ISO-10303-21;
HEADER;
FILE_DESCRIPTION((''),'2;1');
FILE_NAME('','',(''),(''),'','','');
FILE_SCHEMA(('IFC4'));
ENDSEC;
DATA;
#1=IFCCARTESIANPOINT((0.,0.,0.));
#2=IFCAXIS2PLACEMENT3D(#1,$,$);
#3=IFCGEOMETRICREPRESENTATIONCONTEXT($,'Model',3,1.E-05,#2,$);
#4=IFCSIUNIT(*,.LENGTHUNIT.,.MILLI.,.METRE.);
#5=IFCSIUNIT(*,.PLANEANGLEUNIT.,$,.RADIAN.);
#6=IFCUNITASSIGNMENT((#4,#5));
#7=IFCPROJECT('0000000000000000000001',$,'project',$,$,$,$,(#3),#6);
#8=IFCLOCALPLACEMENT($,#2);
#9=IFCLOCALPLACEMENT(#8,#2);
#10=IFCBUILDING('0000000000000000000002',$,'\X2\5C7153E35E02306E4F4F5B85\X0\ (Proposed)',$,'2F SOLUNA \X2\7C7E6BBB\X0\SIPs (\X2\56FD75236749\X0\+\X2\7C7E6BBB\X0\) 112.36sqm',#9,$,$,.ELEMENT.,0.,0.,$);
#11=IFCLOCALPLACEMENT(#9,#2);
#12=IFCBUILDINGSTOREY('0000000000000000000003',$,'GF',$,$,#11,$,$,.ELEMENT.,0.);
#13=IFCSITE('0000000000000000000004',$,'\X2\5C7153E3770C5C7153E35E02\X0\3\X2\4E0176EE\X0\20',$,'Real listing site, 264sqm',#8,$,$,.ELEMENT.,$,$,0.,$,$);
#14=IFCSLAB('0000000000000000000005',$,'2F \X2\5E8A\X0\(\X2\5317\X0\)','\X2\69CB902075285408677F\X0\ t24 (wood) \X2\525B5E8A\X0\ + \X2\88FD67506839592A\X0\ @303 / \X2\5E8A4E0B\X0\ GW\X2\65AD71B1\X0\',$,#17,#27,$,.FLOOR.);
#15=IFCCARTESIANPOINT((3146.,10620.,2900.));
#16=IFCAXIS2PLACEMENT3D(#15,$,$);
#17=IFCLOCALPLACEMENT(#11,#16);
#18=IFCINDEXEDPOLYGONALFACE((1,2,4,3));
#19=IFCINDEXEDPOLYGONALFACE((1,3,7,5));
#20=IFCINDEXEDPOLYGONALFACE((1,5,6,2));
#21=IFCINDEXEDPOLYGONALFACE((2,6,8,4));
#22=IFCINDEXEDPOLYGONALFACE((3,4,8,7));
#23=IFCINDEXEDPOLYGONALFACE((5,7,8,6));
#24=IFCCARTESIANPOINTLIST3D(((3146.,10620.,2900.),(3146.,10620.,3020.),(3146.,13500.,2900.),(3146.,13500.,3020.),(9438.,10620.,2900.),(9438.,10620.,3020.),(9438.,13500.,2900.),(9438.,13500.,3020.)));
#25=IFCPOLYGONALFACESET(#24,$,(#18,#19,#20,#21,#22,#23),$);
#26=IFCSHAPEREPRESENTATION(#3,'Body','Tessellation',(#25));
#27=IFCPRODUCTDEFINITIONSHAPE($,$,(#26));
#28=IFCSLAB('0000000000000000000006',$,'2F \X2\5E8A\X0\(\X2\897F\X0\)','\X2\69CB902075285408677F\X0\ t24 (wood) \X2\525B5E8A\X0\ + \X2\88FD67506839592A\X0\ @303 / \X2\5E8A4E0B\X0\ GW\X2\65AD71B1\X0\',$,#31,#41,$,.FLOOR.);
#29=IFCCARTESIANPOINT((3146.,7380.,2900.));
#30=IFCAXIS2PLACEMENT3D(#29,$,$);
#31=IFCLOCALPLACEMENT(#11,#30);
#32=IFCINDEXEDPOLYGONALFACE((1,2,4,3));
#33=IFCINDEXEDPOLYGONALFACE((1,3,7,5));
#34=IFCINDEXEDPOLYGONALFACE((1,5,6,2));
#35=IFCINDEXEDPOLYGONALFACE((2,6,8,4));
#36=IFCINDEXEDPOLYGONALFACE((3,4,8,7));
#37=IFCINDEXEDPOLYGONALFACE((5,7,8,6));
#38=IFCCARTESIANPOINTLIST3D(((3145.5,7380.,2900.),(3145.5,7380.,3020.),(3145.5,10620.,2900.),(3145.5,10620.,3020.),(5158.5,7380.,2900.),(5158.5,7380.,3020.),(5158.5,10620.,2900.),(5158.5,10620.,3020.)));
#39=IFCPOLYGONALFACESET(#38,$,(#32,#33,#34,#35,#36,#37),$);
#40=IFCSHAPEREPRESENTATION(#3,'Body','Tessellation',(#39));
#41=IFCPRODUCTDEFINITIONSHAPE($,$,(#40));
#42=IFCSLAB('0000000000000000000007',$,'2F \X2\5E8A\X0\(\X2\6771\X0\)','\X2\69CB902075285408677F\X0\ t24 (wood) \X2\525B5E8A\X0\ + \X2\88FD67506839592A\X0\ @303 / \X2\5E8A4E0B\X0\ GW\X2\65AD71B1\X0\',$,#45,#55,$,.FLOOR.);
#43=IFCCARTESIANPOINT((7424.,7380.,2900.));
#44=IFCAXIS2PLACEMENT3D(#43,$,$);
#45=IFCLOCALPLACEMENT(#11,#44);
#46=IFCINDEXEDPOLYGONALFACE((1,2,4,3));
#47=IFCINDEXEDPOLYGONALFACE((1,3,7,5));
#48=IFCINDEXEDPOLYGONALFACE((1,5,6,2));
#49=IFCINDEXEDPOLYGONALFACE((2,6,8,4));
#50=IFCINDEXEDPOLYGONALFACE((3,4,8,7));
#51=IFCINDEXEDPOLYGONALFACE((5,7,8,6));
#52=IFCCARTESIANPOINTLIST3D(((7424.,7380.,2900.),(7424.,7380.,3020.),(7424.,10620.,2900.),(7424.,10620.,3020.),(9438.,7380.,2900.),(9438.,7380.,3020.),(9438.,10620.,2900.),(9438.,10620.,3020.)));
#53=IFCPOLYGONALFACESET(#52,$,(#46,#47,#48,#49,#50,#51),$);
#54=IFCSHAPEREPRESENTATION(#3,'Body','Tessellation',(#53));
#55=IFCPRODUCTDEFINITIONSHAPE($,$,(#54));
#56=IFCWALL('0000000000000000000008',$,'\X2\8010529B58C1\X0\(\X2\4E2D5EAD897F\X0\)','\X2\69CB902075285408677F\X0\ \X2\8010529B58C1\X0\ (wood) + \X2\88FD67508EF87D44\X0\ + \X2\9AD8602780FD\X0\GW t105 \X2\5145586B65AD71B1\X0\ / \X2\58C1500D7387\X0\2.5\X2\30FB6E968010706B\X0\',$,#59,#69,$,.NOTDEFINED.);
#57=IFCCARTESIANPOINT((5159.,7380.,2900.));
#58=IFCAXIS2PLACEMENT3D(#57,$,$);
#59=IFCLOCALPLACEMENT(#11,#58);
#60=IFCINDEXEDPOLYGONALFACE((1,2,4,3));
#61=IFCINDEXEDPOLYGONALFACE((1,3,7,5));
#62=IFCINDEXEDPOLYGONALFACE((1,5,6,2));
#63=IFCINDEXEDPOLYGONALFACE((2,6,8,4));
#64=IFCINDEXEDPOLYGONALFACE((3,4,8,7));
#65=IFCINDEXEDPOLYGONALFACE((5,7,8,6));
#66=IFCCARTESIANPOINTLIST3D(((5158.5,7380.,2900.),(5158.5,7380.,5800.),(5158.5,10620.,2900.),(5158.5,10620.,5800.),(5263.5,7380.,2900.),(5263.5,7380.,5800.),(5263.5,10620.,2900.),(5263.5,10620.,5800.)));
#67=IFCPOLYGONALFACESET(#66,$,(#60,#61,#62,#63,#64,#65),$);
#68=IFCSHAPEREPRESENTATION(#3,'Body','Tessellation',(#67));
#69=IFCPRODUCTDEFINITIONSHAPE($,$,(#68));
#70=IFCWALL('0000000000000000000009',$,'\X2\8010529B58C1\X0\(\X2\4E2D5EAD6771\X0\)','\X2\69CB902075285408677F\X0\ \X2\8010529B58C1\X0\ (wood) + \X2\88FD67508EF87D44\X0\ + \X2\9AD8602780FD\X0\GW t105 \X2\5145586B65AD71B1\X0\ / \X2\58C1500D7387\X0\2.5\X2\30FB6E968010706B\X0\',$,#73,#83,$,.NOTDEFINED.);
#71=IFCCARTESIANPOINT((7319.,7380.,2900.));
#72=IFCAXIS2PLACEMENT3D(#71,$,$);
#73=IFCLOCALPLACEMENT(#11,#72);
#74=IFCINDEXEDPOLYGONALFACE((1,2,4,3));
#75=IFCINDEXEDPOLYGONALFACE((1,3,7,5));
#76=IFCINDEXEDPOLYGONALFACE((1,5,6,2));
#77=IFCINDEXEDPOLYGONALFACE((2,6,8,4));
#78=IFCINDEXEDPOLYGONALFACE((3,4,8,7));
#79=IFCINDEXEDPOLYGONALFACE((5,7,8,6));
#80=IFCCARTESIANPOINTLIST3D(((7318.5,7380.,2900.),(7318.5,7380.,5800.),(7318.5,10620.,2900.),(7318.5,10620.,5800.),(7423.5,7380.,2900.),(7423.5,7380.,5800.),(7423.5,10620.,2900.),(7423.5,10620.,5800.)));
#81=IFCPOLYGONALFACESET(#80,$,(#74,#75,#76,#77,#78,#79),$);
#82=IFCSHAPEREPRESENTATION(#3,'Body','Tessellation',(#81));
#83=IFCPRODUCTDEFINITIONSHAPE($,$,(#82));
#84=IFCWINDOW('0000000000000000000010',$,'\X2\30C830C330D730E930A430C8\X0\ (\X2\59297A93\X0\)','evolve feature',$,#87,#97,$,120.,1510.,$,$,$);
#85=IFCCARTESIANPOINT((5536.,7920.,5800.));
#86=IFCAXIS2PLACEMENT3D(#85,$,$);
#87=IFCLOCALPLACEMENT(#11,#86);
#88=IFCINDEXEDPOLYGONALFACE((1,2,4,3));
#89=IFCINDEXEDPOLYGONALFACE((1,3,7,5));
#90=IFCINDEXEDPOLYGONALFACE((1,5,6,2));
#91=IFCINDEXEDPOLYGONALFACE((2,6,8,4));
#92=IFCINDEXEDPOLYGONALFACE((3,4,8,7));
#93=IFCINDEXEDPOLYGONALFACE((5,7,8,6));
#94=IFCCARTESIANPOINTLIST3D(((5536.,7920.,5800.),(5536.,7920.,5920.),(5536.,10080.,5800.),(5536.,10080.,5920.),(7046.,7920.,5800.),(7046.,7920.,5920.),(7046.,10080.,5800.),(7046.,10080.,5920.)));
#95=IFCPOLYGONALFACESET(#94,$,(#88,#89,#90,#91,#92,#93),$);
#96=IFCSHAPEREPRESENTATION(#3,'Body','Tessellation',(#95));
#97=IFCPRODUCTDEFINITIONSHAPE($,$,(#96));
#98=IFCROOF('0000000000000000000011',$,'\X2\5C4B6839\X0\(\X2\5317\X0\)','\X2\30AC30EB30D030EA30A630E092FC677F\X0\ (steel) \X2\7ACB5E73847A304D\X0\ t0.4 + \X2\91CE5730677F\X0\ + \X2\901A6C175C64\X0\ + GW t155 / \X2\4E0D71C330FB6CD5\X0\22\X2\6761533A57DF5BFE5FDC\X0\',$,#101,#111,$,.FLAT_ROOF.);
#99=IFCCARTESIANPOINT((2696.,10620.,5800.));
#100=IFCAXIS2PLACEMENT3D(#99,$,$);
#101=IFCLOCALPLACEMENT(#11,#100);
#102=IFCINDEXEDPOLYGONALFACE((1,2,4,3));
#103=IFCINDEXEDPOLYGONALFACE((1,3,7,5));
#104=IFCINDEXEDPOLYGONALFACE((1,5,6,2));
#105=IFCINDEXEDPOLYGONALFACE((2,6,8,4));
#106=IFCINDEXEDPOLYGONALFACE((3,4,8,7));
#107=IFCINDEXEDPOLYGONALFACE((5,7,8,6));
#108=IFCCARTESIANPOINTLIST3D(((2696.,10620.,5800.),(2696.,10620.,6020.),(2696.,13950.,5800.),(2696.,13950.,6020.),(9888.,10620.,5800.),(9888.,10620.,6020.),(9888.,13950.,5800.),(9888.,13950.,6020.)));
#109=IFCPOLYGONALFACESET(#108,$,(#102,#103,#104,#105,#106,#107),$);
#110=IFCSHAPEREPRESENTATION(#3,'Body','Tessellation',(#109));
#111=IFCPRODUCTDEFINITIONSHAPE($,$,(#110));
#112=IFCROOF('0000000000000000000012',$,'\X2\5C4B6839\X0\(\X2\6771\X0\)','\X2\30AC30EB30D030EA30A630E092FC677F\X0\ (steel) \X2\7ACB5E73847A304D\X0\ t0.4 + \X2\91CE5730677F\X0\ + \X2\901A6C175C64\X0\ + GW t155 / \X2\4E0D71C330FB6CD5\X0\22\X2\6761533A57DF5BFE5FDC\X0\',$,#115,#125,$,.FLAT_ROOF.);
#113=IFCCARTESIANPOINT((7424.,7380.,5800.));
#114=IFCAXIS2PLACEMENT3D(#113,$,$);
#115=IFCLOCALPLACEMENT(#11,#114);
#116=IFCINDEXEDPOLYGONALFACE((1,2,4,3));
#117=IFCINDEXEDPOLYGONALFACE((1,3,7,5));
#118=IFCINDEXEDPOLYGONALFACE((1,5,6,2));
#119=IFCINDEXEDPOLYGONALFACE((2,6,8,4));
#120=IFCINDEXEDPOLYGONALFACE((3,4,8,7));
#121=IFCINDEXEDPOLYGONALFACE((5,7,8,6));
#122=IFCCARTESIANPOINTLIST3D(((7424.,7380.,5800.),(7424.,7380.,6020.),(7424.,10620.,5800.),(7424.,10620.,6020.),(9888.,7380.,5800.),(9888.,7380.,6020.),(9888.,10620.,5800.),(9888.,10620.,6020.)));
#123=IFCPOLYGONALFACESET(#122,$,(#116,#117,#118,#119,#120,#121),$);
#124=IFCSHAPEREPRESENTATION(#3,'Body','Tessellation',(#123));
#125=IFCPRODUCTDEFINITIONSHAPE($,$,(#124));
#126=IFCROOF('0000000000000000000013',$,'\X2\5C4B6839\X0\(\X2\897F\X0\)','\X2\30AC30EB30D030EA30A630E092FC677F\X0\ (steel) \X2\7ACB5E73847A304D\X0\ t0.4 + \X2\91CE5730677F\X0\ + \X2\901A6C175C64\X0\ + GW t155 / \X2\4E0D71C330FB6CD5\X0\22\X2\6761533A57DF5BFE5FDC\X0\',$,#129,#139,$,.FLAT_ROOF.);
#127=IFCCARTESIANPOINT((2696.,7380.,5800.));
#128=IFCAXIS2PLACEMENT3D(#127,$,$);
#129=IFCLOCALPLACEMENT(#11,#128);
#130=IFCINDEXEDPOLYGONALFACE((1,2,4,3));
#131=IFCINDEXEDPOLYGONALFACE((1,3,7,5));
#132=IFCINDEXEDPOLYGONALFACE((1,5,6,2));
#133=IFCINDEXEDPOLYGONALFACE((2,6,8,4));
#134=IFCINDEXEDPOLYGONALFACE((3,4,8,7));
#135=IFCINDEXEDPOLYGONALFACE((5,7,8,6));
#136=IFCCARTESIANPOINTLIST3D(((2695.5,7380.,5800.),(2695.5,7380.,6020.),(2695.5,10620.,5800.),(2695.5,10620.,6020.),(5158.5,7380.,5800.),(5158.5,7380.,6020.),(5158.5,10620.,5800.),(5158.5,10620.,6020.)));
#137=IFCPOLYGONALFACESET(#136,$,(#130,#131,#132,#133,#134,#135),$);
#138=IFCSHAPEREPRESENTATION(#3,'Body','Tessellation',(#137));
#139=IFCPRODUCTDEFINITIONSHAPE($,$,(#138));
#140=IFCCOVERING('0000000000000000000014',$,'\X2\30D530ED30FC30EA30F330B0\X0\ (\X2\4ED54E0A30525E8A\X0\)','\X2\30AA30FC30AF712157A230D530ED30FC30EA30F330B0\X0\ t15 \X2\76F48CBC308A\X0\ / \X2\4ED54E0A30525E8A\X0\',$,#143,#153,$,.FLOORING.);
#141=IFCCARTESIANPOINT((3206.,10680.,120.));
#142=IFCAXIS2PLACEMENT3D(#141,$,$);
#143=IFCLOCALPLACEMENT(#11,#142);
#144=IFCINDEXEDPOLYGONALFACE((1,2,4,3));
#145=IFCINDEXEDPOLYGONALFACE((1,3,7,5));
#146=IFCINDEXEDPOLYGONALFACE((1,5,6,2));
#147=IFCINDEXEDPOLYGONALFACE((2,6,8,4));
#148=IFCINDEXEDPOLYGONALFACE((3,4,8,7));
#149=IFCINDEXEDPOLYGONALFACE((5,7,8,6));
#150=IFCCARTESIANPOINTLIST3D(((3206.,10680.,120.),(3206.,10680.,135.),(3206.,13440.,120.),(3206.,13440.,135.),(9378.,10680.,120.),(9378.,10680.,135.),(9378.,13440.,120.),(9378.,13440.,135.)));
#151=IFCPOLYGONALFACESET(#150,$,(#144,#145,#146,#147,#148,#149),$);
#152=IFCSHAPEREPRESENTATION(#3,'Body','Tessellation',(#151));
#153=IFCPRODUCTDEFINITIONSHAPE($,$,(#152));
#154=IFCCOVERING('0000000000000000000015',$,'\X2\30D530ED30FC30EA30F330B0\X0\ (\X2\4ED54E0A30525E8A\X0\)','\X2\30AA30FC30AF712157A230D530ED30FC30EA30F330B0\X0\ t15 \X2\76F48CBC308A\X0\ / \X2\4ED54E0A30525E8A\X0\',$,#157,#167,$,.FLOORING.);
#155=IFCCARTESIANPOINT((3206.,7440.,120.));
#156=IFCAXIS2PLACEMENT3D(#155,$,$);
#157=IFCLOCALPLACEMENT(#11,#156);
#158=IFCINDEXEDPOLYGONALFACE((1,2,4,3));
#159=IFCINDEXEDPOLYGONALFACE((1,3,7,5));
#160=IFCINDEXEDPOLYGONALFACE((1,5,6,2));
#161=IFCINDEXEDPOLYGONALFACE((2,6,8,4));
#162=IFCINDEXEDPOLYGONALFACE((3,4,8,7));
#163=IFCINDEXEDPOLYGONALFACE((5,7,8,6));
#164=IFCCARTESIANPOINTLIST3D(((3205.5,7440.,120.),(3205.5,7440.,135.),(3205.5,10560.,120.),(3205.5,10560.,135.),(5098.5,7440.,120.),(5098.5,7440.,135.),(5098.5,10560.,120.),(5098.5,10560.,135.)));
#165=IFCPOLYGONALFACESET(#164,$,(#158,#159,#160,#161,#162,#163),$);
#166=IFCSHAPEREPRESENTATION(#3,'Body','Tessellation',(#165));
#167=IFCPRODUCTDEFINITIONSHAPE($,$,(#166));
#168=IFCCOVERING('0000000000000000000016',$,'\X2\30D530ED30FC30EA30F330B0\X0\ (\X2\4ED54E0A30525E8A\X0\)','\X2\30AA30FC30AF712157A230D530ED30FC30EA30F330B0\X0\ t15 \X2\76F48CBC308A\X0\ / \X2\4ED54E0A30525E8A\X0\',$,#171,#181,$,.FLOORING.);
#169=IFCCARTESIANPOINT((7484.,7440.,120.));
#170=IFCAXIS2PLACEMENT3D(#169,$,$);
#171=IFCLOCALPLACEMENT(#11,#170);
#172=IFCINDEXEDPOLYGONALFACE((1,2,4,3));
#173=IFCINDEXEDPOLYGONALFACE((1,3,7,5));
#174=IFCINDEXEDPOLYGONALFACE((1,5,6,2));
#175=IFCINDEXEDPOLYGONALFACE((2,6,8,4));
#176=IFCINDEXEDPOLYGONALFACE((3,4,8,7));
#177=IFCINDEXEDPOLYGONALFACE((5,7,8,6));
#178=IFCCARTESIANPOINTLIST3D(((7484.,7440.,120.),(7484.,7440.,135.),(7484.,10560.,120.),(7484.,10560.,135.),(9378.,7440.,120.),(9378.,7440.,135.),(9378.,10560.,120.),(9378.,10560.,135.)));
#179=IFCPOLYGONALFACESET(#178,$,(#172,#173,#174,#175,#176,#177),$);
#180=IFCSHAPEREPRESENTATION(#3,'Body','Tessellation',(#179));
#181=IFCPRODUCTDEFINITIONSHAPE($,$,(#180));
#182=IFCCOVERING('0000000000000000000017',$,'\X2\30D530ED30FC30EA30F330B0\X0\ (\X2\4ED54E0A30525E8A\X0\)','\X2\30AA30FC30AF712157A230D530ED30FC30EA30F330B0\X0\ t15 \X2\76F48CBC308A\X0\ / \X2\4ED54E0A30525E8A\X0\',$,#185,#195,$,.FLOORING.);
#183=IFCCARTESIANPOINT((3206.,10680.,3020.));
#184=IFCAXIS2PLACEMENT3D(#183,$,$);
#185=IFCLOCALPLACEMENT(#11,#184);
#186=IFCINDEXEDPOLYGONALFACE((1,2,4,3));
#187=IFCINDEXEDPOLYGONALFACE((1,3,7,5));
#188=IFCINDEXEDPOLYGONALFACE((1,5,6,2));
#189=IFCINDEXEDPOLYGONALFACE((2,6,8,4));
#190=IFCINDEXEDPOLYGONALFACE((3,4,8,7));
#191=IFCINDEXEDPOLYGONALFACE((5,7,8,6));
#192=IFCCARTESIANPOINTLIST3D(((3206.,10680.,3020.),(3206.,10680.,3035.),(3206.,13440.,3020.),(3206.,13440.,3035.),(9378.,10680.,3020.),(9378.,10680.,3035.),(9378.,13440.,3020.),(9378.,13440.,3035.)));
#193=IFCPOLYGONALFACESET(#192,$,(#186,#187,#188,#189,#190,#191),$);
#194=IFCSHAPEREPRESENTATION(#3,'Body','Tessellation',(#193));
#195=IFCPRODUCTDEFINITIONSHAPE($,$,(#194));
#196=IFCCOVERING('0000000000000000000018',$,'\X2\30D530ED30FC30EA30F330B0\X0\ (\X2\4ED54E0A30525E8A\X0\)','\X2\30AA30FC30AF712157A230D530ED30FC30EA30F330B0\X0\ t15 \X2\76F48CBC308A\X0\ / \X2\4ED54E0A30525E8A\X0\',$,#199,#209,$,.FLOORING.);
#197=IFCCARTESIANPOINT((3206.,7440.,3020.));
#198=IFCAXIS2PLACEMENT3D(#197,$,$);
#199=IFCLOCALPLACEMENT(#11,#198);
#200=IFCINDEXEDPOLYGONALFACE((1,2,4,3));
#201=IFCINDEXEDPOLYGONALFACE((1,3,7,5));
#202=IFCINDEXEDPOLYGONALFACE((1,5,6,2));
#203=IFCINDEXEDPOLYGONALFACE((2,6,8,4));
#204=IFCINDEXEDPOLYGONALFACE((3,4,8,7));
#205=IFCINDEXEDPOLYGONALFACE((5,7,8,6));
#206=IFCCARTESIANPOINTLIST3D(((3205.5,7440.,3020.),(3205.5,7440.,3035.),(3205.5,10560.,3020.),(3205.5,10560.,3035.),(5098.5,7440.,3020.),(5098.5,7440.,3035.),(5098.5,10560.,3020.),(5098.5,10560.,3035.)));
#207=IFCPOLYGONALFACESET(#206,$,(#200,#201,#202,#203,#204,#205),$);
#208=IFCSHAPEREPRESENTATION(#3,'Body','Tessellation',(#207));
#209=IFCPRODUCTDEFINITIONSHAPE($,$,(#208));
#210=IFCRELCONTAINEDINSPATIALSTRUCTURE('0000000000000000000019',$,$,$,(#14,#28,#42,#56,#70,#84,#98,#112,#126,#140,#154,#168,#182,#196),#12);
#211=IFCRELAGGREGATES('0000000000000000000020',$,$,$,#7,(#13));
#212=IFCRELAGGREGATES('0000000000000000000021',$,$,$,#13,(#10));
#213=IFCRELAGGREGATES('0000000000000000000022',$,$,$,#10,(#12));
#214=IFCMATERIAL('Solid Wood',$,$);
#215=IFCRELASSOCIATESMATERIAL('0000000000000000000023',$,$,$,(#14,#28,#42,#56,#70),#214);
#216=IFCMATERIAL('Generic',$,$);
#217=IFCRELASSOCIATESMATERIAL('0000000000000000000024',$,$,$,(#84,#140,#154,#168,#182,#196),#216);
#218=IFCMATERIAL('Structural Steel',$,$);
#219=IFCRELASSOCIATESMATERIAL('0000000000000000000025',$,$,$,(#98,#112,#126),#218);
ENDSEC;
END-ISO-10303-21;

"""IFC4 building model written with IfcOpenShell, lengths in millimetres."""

from ifc_helpers import new_model, si_unit, frame, frame_2d, origin, place, context, project, spatial, rectangle, extrude, material, element, save


model = new_model("IFC4")

# Units and contexts
model_context = context("Model", 3, precision=1e-05, world=origin())
ifc_project = project(units=[si_unit("LENGTHUNIT", "METRE", prefix="MILLI"), si_unit("PLANEANGLEUNIT", "RADIAN")], contexts=[model_context])

# Site, building, storey
site_placement = place(None, origin())
site = spatial("IfcSite", under=ifc_project, at=site_placement, Name="山口県山口市3丁目20", ObjectType="Real listing site, 264sqm", CompositionType="ELEMENT", RefElevation=0.0)
building_placement = place(site_placement, origin())
building = spatial("IfcBuilding", under=site, at=building_placement, Name="山口市の住宅 (Proposed)", ObjectType="2F SOLUNA 籾殻SIPs (国産杉+籾殻) 112.36sqm", CompositionType="ELEMENT", ElevationOfRefHeight=0.0, ElevationOfTerrain=0.0)
storey_placement = place(building_placement, origin())
storey = spatial("IfcBuildingStorey", under=building, at=storey_placement, Name="GF", CompositionType="ELEMENT", Elevation=0.0)

# Slabs
ifc_material_1 = material(Name="Solid Wood")
slab_1_placement = place(storey_placement, frame((3146.0, 10620.0, 2900.0)))
element("IfcSlab", 1, at=slab_1_placement, inside=storey, material=ifc_material_1, Name="2F 床(北)", Description="構造用合板 t24 (wood) 剛床 + 製材根太 @303 / 床下 GW断熱", PredefinedType="FLOOR", context=model_context, shape_type="SweptSolid", body=[
    extrude(rectangle(XDim=6292.0, YDim=2880.0, at=frame_2d((3146.0, 1440.0))), frame((3146.0, 10620.0, 2900.0)), (0.0, 0.0, 1.0), 120.0),
])
slab_2_placement = place(storey_placement, frame((3146.0, 7380.0, 2900.0)))
element("IfcSlab", 2, at=slab_2_placement, inside=storey, material=ifc_material_1, Name="2F 床(西)", Description="構造用合板 t24 (wood) 剛床 + 製材根太 @303 / 床下 GW断熱", PredefinedType="FLOOR", context=model_context, shape_type="SweptSolid", body=[
    extrude(rectangle(XDim=2013.0, YDim=3240.0, at=frame_2d((1006.0, 1620.0))), frame((3146.0, 7380.0, 2900.0)), (0.0, 0.0, 1.0), 120.0),
])
slab_3_placement = place(storey_placement, frame((7424.0, 7380.0, 2900.0)))
element("IfcSlab", 3, at=slab_3_placement, inside=storey, material=ifc_material_1, Name="2F 床(東)", Description="構造用合板 t24 (wood) 剛床 + 製材根太 @303 / 床下 GW断熱", PredefinedType="FLOOR", context=model_context, shape_type="SweptSolid", body=[
    extrude(rectangle(XDim=2014.0, YDim=3240.0, at=frame_2d((1007.0, 1620.0))), frame((7424.0, 7380.0, 2900.0)), (0.0, 0.0, 1.0), 120.0),
])

# Walls
wall_1_placement = place(storey_placement, frame((5159.0, 7380.0, 2900.0)))
element("IfcWall", 4, at=wall_1_placement, inside=storey, material=ifc_material_1, Name="耐力壁(中庭西)", Description="構造用合板 耐力壁 (wood) + 製材軸組 + 高性能GW t105 充填断熱 / 壁倍率2.5・準耐火", PredefinedType="NOTDEFINED", context=model_context, shape_type="SweptSolid", body=[
    extrude(rectangle(XDim=105.0, YDim=3240.0, at=frame_2d((52.0, 1620.0))), frame((5159.0, 7380.0, 2900.0)), (0.0, 0.0, 1.0), 2900.0),
])
wall_2_placement = place(storey_placement, frame((7319.0, 7380.0, 2900.0)))
element("IfcWall", 5, at=wall_2_placement, inside=storey, material=ifc_material_1, Name="耐力壁(中庭東)", Description="構造用合板 耐力壁 (wood) + 製材軸組 + 高性能GW t105 充填断熱 / 壁倍率2.5・準耐火", PredefinedType="NOTDEFINED", context=model_context, shape_type="SweptSolid", body=[
    extrude(rectangle(XDim=105.0, YDim=3240.0, at=frame_2d((52.0, 1620.0))), frame((7319.0, 7380.0, 2900.0)), (0.0, 0.0, 1.0), 2900.0),
])

# Window
ifc_material_2 = material(Name="Generic")
window_1_placement = place(storey_placement, frame((5536.0, 7920.0, 5800.0)))
element("IfcWindow", 6, at=window_1_placement, inside=storey, material=ifc_material_2, Name="トップライト (天窓)", Description="evolve feature", OverallHeight=120.0, OverallWidth=1510.0, context=model_context, shape_type="SweptSolid", body=[
    extrude(rectangle(XDim=1510.0, YDim=2160.0, at=frame_2d((755.0, 1080.0))), frame((5536.0, 7920.0, 5800.0)), (0.0, 0.0, 1.0), 120.0),
])

# Roofs
ifc_material_3 = material(Name="Structural Steel")
roof_1_placement = place(storey_placement, frame((2696.0, 10620.0, 5800.0)))
element("IfcRoof", 7, at=roof_1_placement, inside=storey, material=ifc_material_3, Name="屋根(北)", Description="ガルバリウム鋼板 (steel) 立平葺き t0.4 + 野地板 + 通気層 + GW t155 / 不燃・法22条区域対応", PredefinedType="FLAT_ROOF", context=model_context, shape_type="SweptSolid", body=[
    extrude(rectangle(XDim=7192.0, YDim=3330.0, at=frame_2d((3596.0, 1665.0))), frame((2696.0, 10620.0, 5800.0)), (0.0, 0.0, 1.0), 220.0),
])
roof_2_placement = place(storey_placement, frame((7424.0, 7380.0, 5800.0)))
element("IfcRoof", 8, at=roof_2_placement, inside=storey, material=ifc_material_3, Name="屋根(東)", Description="ガルバリウム鋼板 (steel) 立平葺き t0.4 + 野地板 + 通気層 + GW t155 / 不燃・法22条区域対応", PredefinedType="FLAT_ROOF", context=model_context, shape_type="SweptSolid", body=[
    extrude(rectangle(XDim=2464.0, YDim=3240.0, at=frame_2d((1232.0, 1620.0))), frame((7424.0, 7380.0, 5800.0)), (0.0, 0.0, 1.0), 220.0),
])
roof_3_placement = place(storey_placement, frame((2696.0, 7380.0, 5800.0)))
element("IfcRoof", 9, at=roof_3_placement, inside=storey, material=ifc_material_3, Name="屋根(西)", Description="ガルバリウム鋼板 (steel) 立平葺き t0.4 + 野地板 + 通気層 + GW t155 / 不燃・法22条区域対応", PredefinedType="FLAT_ROOF", context=model_context, shape_type="SweptSolid", body=[
    extrude(rectangle(XDim=2463.0, YDim=3240.0, at=frame_2d((1231.0, 1620.0))), frame((2696.0, 7380.0, 5800.0)), (0.0, 0.0, 1.0), 220.0),
])

# Coverings
covering_1_placement = place(storey_placement, frame((3206.0, 10680.0, 120.0)))
element("IfcCovering", 10, at=covering_1_placement, inside=storey, material=ifc_material_2, Name="フローリング (仕上げ床)", Description="オーク無垢フローリング t15 直貼り / 仕上げ床", PredefinedType="FLOORING", context=model_context, shape_type="SweptSolid", body=[
    extrude(rectangle(XDim=6172.0, YDim=2760.0, at=frame_2d((3086.0, 1380.0))), frame((3206.0, 10680.0, 120.0)), (0.0, 0.0, 1.0), 15.0),
])
covering_2_placement = place(storey_placement, frame((3206.0, 7440.0, 120.0)))
element("IfcCovering", 11, at=covering_2_placement, inside=storey, material=ifc_material_2, Name="フローリング (仕上げ床)", Description="オーク無垢フローリング t15 直貼り / 仕上げ床", PredefinedType="FLOORING", context=model_context, shape_type="SweptSolid", body=[
    extrude(rectangle(XDim=1893.0, YDim=3120.0, at=frame_2d((946.0, 1560.0))), frame((3206.0, 7440.0, 120.0)), (0.0, 0.0, 1.0), 15.0),
])
covering_3_placement = place(storey_placement, frame((7484.0, 7440.0, 120.0)))
element("IfcCovering", 12, at=covering_3_placement, inside=storey, material=ifc_material_2, Name="フローリング (仕上げ床)", Description="オーク無垢フローリング t15 直貼り / 仕上げ床", PredefinedType="FLOORING", context=model_context, shape_type="SweptSolid", body=[
    extrude(rectangle(XDim=1894.0, YDim=3120.0, at=frame_2d((947.0, 1560.0))), frame((7484.0, 7440.0, 120.0)), (0.0, 0.0, 1.0), 15.0),
])
covering_4_placement = place(storey_placement, frame((3206.0, 10680.0, 3020.0)))
element("IfcCovering", 13, at=covering_4_placement, inside=storey, material=ifc_material_2, Name="フローリング (仕上げ床)", Description="オーク無垢フローリング t15 直貼り / 仕上げ床", PredefinedType="FLOORING", context=model_context, shape_type="SweptSolid", body=[
    extrude(rectangle(XDim=6172.0, YDim=2760.0, at=frame_2d((3086.0, 1380.0))), frame((3206.0, 10680.0, 3020.0)), (0.0, 0.0, 1.0), 15.0),
])
covering_5_placement = place(storey_placement, frame((3206.0, 7440.0, 3020.0)))
element("IfcCovering", 14, at=covering_5_placement, inside=storey, material=ifc_material_2, Name="フローリング (仕上げ床)", Description="オーク無垢フローリング t15 直貼り / 仕上げ床", PredefinedType="FLOORING", context=model_context, shape_type="SweptSolid", body=[
    extrude(rectangle(XDim=1893.0, YDim=3120.0, at=frame_2d((946.0, 1560.0))), frame((3206.0, 7440.0, 3020.0)), (0.0, 0.0, 1.0), 15.0),
])

save(model, "model.ifc")
